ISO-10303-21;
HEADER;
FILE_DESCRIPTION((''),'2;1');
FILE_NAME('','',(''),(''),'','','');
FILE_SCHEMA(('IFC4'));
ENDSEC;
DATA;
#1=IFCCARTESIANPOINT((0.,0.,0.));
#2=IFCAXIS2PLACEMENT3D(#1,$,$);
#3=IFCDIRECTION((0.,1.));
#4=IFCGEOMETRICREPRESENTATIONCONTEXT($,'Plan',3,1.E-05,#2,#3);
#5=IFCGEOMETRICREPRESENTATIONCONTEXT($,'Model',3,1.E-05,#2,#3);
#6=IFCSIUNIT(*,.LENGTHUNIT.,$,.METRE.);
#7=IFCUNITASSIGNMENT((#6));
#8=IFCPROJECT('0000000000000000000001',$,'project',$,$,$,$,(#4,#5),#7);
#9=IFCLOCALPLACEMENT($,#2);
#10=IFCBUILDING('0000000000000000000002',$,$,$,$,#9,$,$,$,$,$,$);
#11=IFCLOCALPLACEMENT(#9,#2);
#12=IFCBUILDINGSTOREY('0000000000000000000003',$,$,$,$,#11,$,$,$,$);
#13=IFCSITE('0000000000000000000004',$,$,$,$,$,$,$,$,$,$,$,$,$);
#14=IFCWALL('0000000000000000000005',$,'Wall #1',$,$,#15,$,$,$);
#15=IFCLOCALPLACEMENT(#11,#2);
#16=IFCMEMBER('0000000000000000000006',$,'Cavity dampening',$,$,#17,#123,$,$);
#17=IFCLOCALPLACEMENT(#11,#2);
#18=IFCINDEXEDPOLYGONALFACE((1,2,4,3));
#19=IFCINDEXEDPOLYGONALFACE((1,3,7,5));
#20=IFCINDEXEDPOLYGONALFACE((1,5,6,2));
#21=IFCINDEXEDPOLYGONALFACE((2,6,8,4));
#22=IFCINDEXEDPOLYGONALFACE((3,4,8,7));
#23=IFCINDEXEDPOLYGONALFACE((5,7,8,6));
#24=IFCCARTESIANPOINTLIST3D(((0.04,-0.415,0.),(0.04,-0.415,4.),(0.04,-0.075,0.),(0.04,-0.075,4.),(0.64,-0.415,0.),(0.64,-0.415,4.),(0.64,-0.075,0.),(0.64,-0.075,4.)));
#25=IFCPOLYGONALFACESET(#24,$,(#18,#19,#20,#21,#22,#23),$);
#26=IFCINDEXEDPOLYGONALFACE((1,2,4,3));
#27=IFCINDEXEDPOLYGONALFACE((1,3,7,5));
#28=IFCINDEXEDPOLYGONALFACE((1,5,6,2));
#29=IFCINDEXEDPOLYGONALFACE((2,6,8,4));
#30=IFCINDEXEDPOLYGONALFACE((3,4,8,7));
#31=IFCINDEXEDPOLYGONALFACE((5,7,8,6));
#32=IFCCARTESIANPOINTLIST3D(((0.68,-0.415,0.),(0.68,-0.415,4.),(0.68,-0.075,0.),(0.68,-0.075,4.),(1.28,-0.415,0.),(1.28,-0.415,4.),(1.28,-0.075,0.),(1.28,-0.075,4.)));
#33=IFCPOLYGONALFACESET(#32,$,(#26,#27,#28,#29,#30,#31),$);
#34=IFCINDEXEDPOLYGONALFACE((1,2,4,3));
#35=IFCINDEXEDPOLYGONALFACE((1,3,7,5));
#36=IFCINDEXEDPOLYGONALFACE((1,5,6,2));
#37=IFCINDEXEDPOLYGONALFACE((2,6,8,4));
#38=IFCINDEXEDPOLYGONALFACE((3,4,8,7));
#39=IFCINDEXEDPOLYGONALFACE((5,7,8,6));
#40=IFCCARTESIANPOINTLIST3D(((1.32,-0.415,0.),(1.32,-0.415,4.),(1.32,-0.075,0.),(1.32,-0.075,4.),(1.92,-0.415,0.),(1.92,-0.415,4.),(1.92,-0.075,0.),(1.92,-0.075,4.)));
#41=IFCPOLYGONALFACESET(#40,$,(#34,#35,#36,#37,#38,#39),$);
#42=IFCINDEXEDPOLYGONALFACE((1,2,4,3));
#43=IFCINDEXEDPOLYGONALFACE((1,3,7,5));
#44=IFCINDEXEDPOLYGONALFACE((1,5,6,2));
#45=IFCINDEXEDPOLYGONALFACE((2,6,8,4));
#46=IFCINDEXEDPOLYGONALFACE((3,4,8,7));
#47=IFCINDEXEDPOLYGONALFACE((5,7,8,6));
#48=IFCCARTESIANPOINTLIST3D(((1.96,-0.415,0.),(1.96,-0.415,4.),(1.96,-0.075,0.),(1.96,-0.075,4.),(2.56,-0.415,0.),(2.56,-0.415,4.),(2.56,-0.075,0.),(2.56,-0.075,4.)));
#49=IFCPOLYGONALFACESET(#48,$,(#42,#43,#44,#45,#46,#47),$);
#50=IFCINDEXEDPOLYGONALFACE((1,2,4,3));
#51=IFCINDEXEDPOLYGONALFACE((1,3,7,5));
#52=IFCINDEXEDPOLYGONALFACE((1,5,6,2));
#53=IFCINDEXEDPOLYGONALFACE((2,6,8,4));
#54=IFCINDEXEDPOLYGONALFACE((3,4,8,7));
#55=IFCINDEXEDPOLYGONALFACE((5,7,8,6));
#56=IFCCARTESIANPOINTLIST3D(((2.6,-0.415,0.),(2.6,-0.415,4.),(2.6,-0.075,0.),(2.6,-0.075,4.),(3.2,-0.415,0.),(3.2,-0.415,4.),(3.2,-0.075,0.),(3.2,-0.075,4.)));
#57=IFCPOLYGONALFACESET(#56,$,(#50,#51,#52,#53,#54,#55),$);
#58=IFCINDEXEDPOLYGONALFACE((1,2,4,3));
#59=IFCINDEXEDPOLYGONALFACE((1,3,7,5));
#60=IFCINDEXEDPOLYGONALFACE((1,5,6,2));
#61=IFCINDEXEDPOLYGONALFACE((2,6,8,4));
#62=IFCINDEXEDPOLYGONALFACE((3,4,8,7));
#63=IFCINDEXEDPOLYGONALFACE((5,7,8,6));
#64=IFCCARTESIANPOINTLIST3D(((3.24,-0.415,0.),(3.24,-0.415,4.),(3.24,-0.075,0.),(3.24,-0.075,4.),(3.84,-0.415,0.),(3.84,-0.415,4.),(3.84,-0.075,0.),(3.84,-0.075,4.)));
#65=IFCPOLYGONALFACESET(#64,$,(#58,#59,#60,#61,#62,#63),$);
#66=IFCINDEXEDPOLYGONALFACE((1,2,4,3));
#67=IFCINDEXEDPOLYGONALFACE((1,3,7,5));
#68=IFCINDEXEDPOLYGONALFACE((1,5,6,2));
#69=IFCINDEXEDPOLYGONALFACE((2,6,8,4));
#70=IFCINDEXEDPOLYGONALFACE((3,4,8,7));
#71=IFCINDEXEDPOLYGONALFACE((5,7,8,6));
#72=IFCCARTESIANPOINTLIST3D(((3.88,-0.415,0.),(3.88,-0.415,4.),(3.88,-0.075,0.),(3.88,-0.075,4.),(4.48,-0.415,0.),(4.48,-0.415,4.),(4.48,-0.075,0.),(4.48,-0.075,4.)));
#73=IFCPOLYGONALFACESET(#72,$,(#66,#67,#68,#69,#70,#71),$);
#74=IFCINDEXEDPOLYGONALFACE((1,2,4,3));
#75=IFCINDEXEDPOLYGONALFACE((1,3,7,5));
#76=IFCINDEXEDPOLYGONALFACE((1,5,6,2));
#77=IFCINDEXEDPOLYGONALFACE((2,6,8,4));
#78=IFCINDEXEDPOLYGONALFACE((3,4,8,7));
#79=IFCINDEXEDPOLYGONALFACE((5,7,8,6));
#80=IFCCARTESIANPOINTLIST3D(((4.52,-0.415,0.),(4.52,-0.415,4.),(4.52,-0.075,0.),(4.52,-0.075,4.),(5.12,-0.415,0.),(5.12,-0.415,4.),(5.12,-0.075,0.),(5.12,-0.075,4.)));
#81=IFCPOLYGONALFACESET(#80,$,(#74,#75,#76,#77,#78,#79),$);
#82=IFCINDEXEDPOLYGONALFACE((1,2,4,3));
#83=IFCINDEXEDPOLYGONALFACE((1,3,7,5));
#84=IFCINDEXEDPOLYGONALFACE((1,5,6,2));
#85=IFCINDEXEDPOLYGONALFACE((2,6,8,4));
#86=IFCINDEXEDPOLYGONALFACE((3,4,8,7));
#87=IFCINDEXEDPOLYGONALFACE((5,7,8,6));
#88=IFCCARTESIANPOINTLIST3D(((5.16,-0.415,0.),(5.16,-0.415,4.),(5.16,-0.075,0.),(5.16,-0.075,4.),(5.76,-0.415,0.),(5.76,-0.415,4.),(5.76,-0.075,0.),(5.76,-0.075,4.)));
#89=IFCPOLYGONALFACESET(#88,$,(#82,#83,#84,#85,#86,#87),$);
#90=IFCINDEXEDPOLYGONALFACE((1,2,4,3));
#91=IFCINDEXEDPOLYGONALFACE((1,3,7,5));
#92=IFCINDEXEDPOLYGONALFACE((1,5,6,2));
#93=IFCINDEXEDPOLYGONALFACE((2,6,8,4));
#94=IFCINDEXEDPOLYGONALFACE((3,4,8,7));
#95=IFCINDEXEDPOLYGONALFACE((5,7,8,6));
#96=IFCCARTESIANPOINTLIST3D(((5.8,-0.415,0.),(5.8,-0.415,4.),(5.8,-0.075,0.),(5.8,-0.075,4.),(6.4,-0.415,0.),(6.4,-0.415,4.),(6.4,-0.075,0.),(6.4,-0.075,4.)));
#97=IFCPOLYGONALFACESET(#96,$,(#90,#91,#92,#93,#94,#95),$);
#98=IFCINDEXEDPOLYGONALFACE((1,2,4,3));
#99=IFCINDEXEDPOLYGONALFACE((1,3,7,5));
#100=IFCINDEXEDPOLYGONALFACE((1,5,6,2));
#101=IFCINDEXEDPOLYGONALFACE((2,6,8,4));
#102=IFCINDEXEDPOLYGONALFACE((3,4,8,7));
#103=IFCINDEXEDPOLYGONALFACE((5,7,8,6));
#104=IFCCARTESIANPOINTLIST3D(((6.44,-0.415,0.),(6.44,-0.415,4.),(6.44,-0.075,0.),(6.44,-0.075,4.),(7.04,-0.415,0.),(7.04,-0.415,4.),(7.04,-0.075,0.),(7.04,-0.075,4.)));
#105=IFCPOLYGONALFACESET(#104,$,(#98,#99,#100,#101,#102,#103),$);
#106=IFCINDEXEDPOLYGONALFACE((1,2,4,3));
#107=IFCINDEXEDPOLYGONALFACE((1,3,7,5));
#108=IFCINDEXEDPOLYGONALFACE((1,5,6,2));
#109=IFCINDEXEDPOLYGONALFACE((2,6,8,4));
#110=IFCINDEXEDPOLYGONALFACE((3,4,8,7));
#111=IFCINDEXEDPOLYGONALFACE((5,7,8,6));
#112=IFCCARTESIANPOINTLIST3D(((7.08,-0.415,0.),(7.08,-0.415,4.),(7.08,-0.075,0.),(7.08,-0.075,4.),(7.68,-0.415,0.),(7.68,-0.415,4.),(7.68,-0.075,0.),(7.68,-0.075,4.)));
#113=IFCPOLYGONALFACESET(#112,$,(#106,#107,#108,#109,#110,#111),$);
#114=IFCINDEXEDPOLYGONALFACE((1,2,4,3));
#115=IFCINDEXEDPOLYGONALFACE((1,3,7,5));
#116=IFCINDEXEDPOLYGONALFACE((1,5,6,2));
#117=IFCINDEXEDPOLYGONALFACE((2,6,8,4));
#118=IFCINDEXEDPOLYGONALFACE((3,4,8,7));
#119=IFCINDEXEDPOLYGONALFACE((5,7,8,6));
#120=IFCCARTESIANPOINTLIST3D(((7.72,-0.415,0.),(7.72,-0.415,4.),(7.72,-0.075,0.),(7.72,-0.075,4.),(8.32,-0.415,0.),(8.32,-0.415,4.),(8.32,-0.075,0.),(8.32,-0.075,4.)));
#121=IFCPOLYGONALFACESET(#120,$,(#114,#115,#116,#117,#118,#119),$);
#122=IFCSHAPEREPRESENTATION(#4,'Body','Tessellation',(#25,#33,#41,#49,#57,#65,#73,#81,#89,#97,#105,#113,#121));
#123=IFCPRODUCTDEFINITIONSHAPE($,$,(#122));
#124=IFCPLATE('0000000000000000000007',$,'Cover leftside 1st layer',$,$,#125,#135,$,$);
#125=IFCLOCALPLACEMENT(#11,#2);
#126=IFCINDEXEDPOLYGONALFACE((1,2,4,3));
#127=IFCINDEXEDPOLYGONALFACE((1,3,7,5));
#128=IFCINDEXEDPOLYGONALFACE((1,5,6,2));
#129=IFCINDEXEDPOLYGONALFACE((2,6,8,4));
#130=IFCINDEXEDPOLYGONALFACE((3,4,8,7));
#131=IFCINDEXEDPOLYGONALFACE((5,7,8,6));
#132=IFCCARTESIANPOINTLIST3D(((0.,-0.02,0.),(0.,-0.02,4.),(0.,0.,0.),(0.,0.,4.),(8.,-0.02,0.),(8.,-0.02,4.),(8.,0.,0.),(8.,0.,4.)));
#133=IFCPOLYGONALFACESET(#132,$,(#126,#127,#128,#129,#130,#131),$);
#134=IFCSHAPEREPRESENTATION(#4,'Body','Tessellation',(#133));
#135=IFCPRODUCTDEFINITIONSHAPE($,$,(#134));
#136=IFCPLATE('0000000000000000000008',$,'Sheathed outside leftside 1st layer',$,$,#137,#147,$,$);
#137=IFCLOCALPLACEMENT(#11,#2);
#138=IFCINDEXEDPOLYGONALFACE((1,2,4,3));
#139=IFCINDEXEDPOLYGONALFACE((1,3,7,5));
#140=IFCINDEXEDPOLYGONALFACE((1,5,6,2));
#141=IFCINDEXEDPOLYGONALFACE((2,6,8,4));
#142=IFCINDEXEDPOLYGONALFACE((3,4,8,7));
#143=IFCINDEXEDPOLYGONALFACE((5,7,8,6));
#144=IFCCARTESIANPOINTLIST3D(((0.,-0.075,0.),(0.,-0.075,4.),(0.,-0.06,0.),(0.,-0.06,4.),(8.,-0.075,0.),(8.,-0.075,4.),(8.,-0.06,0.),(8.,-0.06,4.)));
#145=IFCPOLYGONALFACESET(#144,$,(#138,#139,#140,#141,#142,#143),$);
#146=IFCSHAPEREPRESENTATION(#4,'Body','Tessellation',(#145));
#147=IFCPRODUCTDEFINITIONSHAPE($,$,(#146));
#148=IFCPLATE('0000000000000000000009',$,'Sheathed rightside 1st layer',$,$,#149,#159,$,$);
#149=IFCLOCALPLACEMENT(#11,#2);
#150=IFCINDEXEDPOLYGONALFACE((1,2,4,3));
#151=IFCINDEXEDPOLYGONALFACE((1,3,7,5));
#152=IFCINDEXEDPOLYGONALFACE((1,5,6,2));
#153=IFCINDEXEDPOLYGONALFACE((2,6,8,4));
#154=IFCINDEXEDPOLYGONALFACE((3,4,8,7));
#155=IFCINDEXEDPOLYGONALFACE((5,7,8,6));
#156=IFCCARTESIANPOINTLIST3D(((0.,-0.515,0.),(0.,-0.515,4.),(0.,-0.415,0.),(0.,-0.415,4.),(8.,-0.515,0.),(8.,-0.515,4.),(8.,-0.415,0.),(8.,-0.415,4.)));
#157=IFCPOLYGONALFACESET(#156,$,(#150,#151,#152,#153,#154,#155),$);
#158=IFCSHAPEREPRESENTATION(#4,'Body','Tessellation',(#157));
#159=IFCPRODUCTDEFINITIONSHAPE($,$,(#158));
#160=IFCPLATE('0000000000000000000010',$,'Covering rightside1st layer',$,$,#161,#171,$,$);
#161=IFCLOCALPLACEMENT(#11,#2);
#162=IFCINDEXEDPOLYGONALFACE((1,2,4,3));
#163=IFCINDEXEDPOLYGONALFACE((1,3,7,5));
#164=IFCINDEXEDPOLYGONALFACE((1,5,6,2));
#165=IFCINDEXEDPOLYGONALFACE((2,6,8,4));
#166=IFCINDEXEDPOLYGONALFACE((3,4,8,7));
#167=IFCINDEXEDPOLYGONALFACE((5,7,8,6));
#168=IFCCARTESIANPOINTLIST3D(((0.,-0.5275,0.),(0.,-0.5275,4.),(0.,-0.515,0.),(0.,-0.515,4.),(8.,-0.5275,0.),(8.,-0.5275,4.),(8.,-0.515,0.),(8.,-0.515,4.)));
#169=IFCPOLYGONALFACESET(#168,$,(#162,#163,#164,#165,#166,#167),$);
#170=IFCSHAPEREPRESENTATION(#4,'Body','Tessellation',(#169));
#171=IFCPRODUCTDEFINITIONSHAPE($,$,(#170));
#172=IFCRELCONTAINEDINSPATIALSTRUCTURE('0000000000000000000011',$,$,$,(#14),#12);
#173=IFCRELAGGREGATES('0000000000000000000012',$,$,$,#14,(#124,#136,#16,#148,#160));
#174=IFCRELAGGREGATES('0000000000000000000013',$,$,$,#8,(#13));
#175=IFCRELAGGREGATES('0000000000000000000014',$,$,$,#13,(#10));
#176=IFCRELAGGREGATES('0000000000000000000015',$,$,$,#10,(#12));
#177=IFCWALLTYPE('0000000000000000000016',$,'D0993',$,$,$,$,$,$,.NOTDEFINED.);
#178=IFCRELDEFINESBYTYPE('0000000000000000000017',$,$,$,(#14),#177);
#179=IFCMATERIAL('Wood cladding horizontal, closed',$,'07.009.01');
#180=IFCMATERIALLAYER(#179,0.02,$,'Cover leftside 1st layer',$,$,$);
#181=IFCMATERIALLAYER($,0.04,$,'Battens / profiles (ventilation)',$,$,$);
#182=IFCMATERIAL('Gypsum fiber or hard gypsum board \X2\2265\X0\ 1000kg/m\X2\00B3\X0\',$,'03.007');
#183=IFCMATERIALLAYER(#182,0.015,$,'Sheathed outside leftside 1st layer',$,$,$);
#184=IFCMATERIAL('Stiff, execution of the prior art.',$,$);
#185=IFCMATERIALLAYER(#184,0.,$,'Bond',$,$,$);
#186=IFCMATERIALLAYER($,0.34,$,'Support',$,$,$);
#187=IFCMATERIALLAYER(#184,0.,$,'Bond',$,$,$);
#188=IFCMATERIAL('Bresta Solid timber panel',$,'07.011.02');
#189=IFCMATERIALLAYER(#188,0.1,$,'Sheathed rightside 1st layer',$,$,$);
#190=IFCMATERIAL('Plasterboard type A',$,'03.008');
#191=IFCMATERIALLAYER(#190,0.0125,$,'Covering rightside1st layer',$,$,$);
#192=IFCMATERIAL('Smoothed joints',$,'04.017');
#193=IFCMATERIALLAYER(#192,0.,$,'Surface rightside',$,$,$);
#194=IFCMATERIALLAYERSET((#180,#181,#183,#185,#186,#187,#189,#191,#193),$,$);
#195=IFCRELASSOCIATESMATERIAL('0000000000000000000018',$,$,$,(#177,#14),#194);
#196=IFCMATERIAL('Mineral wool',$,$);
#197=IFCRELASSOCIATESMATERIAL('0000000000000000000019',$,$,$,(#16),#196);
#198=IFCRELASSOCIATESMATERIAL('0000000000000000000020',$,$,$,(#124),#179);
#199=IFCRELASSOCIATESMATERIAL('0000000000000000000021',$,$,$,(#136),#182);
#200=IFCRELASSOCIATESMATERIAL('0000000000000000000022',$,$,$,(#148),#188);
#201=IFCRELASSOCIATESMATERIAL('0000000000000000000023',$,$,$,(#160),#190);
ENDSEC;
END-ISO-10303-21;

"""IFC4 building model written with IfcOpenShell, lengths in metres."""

from ifc_helpers import new_model, si_unit, direction, frame, frame_2d, origin, origin_with_axes, place, context, project, spatial, rectangle, extrude, material, layer, layer_set, type_object, element, aggregate, save


model = new_model("IFC4")

# Units and contexts
plan_context = context("Plan", 3, precision=1e-05, world=origin(), true_north=direction((0.0, 1.0)))
model_context = context("Model", 3, precision=1e-05, world=origin(), true_north=direction((0.0, 1.0)))
ifc_project = project(units=[si_unit("LENGTHUNIT", "METRE")], contexts=[plan_context, model_context])

# Site, building, storey
site = spatial("IfcSite", under=ifc_project)
building_placement = place(None, origin())
building = spatial("IfcBuilding", under=site, at=building_placement)
storey_placement = place(building_placement, origin())
storey = spatial("IfcBuildingStorey", under=building, at=storey_placement)

# Wall, member, plates
ifc_material_1 = material(Name="Wood cladding horizontal, closed", Category="07.009.01")
ifc_layer_1 = layer(ifc_material_1, 0.02, Name="Cover leftside 1st layer")
ifc_layer_2 = layer(None, 0.04, Name="Battens / profiles (ventilation)")
ifc_material_2 = material(Name="Gypsum fiber or hard gypsum board ≥ 1000kg/m³", Category="03.007")
ifc_layer_3 = layer(ifc_material_2, 0.015, Name="Sheathed outside leftside 1st layer")
ifc_material_3 = material(Name="Stiff, execution of the prior art.")
ifc_layer_4 = layer(ifc_material_3, 0.0, Name="Bond")
ifc_layer_5 = layer(None, 0.34, Name="Support")
ifc_layer_6 = layer(ifc_material_3, 0.0, Name="Bond")
ifc_material_4 = material(Name="Bresta Solid timber panel", Category="07.011.02")
ifc_layer_7 = layer(ifc_material_4, 0.1, Name="Sheathed rightside 1st layer")
ifc_material_5 = material(Name="Plasterboard type A", Category="03.008")
ifc_layer_8 = layer(ifc_material_5, 0.0125, Name="Covering rightside1st layer")
ifc_material_6 = material(Name="Smoothed joints", Category="04.017")
ifc_layer_9 = layer(ifc_material_6, 0.0, Name="Surface rightside")
ifc_layer_set = layer_set([ifc_layer_1, ifc_layer_2, ifc_layer_3, ifc_layer_4, ifc_layer_5, ifc_layer_6, ifc_layer_7, ifc_layer_8, ifc_layer_9])
wall_type = type_object("IfcWallType", Name="D0993", PredefinedType="NOTDEFINED", material=ifc_layer_set)
wall_placement = place(None, frame((0.0, 0.0, 0.0), z_axis=(0.0, -1.0, 0.0), x_axis=(1.0, 0.0, 0.0)))
wall = element("IfcWall", 1, at=wall_placement, inside=storey, type_object=wall_type, material=ifc_layer_set, Name="Wall #1")
ifc_material_7 = material(Name="Mineral wool")
member_1_placement = place(wall_placement, origin())
member_1 = element("IfcMember", 2, at=member_1_placement, material=ifc_material_7, Name="Cavity dampening", context=plan_context, shape_type="SweptSolid", body=[
    extrude(rectangle(XDim=0.6, YDim=0.34, at=frame_2d((0.3, 0.17), x_axis=(1.0, 0.0))), frame((0.04, 4.0, 0.075), z_axis=(0.0, -1.0, 0.0), x_axis=(1.0, 0.0, 0.0)), (0.0, 0.0, 1.0), 4.0),
    extrude(rectangle(XDim=0.6, YDim=0.34, at=frame_2d((0.3, 0.17), x_axis=(1.0, 0.0))), frame((0.68, 4.0, 0.075), z_axis=(0.0, -1.0, 0.0), x_axis=(1.0, 0.0, 0.0)), (0.0, 0.0, 1.0), 4.0),
    extrude(rectangle(XDim=0.6, YDim=0.34, at=frame_2d((0.3, 0.17), x_axis=(1.0, 0.0))), frame((1.32, 4.0, 0.075), z_axis=(0.0, -1.0, 0.0), x_axis=(1.0, 0.0, 0.0)), (0.0, 0.0, 1.0), 4.0),
    extrude(rectangle(XDim=0.6, YDim=0.34, at=frame_2d((0.3, 0.17), x_axis=(1.0, 0.0))), frame((1.96, 4.0, 0.075), z_axis=(0.0, -1.0, 0.0), x_axis=(1.0, 0.0, 0.0)), (0.0, 0.0, 1.0), 4.0),
    extrude(rectangle(XDim=0.6, YDim=0.34, at=frame_2d((0.3, 0.17), x_axis=(1.0, 0.0))), frame((2.6, 4.0, 0.075), z_axis=(0.0, -1.0, 0.0), x_axis=(1.0, 0.0, 0.0)), (0.0, 0.0, 1.0), 4.0),
    extrude(rectangle(XDim=0.6, YDim=0.34, at=frame_2d((0.3, 0.17), x_axis=(1.0, 0.0))), frame((3.24, 4.0, 0.075), z_axis=(0.0, -1.0, 0.0), x_axis=(1.0, 0.0, 0.0)), (0.0, 0.0, 1.0), 4.0),
    extrude(rectangle(XDim=0.6, YDim=0.34, at=frame_2d((0.3, 0.17), x_axis=(1.0, 0.0))), frame((3.88, 4.0, 0.075), z_axis=(0.0, -1.0, 0.0), x_axis=(1.0, 0.0, 0.0)), (0.0, 0.0, 1.0), 4.0),
    extrude(rectangle(XDim=0.6, YDim=0.34, at=frame_2d((0.3, 0.17), x_axis=(1.0, 0.0))), frame((4.52, 4.0, 0.075), z_axis=(0.0, -1.0, 0.0), x_axis=(1.0, 0.0, 0.0)), (0.0, 0.0, 1.0), 4.0),
    extrude(rectangle(XDim=0.6, YDim=0.34, at=frame_2d((0.3, 0.17), x_axis=(1.0, 0.0))), frame((5.16, 4.0, 0.075), z_axis=(0.0, -1.0, 0.0), x_axis=(1.0, 0.0, 0.0)), (0.0, 0.0, 1.0), 4.0),
    extrude(rectangle(XDim=0.6, YDim=0.34, at=frame_2d((0.3, 0.17), x_axis=(1.0, 0.0))), frame((5.8, 4.0, 0.075), z_axis=(0.0, -1.0, 0.0), x_axis=(1.0, 0.0, 0.0)), (0.0, 0.0, 1.0), 4.0),
    extrude(rectangle(XDim=0.6, YDim=0.34, at=frame_2d((0.3, 0.17), x_axis=(1.0, 0.0))), frame((6.44, 4.0, 0.075), z_axis=(0.0, -1.0, 0.0), x_axis=(1.0, 0.0, 0.0)), (0.0, 0.0, 1.0), 4.0),
    extrude(rectangle(XDim=0.6, YDim=0.34, at=frame_2d((0.3, 0.17), x_axis=(1.0, 0.0))), frame((7.08, 4.0, 0.075), z_axis=(0.0, -1.0, 0.0), x_axis=(1.0, 0.0, 0.0)), (0.0, 0.0, 1.0), 4.0),
    extrude(rectangle(XDim=0.6, YDim=0.34, at=frame_2d((0.3, 0.17), x_axis=(1.0, 0.0))), frame((7.72, 4.0, 0.075), z_axis=(0.0, -1.0, 0.0), x_axis=(1.0, 0.0, 0.0)), (0.0, 0.0, 1.0), 4.0),
])
plate_1_placement = place(wall_placement, origin())
plate_1 = element("IfcPlate", 3, at=plate_1_placement, material=ifc_material_1, Name="Cover leftside 1st layer", context=plan_context, shape_type="SweptSolid", body=[
    extrude(rectangle(XDim=8.0, YDim=4.0, at=frame_2d((4.0, 2.0), x_axis=(1.0, 0.0))), origin_with_axes(), (0.0, 0.0, 1.0), 0.02),
])
plate_2_placement = place(wall_placement, origin())
plate_2 = element("IfcPlate", 4, at=plate_2_placement, material=ifc_material_2, Name="Sheathed outside leftside 1st layer", context=plan_context, shape_type="SweptSolid", body=[
    extrude(rectangle(XDim=8.0, YDim=4.0, at=frame_2d((4.0, 2.0), x_axis=(1.0, 0.0))), frame((0.0, 0.0, 0.06), z_axis=(0.0, 0.0, 1.0), x_axis=(1.0, 0.0, 0.0)), (0.0, 0.0, 1.0), 0.015),
])
plate_3_placement = place(wall_placement, origin())
plate_3 = element("IfcPlate", 5, at=plate_3_placement, material=ifc_material_4, Name="Sheathed rightside 1st layer", context=plan_context, shape_type="SweptSolid", body=[
    extrude(rectangle(XDim=8.0, YDim=4.0, at=frame_2d((4.0, 2.0), x_axis=(1.0, 0.0))), frame((0.0, 0.0, 0.415), z_axis=(0.0, 0.0, 1.0), x_axis=(1.0, 0.0, 0.0)), (0.0, 0.0, 1.0), 0.1),
])
plate_4_placement = place(wall_placement, origin())
plate_4 = element("IfcPlate", 6, at=plate_4_placement, material=ifc_material_5, Name="Covering rightside1st layer", context=plan_context, shape_type="SweptSolid", body=[
    extrude(rectangle(XDim=8.0, YDim=4.0, at=frame_2d((4.0, 2.0), x_axis=(1.0, 0.0))), frame((0.0, 0.0, 0.515), z_axis=(0.0, 0.0, 1.0), x_axis=(1.0, 0.0, 0.0)), (0.0, 0.0, 1.0), 0.0125),
])
aggregate(wall, [plate_1, plate_2, member_1, plate_3, plate_4])

save(model, "model.ifc")
